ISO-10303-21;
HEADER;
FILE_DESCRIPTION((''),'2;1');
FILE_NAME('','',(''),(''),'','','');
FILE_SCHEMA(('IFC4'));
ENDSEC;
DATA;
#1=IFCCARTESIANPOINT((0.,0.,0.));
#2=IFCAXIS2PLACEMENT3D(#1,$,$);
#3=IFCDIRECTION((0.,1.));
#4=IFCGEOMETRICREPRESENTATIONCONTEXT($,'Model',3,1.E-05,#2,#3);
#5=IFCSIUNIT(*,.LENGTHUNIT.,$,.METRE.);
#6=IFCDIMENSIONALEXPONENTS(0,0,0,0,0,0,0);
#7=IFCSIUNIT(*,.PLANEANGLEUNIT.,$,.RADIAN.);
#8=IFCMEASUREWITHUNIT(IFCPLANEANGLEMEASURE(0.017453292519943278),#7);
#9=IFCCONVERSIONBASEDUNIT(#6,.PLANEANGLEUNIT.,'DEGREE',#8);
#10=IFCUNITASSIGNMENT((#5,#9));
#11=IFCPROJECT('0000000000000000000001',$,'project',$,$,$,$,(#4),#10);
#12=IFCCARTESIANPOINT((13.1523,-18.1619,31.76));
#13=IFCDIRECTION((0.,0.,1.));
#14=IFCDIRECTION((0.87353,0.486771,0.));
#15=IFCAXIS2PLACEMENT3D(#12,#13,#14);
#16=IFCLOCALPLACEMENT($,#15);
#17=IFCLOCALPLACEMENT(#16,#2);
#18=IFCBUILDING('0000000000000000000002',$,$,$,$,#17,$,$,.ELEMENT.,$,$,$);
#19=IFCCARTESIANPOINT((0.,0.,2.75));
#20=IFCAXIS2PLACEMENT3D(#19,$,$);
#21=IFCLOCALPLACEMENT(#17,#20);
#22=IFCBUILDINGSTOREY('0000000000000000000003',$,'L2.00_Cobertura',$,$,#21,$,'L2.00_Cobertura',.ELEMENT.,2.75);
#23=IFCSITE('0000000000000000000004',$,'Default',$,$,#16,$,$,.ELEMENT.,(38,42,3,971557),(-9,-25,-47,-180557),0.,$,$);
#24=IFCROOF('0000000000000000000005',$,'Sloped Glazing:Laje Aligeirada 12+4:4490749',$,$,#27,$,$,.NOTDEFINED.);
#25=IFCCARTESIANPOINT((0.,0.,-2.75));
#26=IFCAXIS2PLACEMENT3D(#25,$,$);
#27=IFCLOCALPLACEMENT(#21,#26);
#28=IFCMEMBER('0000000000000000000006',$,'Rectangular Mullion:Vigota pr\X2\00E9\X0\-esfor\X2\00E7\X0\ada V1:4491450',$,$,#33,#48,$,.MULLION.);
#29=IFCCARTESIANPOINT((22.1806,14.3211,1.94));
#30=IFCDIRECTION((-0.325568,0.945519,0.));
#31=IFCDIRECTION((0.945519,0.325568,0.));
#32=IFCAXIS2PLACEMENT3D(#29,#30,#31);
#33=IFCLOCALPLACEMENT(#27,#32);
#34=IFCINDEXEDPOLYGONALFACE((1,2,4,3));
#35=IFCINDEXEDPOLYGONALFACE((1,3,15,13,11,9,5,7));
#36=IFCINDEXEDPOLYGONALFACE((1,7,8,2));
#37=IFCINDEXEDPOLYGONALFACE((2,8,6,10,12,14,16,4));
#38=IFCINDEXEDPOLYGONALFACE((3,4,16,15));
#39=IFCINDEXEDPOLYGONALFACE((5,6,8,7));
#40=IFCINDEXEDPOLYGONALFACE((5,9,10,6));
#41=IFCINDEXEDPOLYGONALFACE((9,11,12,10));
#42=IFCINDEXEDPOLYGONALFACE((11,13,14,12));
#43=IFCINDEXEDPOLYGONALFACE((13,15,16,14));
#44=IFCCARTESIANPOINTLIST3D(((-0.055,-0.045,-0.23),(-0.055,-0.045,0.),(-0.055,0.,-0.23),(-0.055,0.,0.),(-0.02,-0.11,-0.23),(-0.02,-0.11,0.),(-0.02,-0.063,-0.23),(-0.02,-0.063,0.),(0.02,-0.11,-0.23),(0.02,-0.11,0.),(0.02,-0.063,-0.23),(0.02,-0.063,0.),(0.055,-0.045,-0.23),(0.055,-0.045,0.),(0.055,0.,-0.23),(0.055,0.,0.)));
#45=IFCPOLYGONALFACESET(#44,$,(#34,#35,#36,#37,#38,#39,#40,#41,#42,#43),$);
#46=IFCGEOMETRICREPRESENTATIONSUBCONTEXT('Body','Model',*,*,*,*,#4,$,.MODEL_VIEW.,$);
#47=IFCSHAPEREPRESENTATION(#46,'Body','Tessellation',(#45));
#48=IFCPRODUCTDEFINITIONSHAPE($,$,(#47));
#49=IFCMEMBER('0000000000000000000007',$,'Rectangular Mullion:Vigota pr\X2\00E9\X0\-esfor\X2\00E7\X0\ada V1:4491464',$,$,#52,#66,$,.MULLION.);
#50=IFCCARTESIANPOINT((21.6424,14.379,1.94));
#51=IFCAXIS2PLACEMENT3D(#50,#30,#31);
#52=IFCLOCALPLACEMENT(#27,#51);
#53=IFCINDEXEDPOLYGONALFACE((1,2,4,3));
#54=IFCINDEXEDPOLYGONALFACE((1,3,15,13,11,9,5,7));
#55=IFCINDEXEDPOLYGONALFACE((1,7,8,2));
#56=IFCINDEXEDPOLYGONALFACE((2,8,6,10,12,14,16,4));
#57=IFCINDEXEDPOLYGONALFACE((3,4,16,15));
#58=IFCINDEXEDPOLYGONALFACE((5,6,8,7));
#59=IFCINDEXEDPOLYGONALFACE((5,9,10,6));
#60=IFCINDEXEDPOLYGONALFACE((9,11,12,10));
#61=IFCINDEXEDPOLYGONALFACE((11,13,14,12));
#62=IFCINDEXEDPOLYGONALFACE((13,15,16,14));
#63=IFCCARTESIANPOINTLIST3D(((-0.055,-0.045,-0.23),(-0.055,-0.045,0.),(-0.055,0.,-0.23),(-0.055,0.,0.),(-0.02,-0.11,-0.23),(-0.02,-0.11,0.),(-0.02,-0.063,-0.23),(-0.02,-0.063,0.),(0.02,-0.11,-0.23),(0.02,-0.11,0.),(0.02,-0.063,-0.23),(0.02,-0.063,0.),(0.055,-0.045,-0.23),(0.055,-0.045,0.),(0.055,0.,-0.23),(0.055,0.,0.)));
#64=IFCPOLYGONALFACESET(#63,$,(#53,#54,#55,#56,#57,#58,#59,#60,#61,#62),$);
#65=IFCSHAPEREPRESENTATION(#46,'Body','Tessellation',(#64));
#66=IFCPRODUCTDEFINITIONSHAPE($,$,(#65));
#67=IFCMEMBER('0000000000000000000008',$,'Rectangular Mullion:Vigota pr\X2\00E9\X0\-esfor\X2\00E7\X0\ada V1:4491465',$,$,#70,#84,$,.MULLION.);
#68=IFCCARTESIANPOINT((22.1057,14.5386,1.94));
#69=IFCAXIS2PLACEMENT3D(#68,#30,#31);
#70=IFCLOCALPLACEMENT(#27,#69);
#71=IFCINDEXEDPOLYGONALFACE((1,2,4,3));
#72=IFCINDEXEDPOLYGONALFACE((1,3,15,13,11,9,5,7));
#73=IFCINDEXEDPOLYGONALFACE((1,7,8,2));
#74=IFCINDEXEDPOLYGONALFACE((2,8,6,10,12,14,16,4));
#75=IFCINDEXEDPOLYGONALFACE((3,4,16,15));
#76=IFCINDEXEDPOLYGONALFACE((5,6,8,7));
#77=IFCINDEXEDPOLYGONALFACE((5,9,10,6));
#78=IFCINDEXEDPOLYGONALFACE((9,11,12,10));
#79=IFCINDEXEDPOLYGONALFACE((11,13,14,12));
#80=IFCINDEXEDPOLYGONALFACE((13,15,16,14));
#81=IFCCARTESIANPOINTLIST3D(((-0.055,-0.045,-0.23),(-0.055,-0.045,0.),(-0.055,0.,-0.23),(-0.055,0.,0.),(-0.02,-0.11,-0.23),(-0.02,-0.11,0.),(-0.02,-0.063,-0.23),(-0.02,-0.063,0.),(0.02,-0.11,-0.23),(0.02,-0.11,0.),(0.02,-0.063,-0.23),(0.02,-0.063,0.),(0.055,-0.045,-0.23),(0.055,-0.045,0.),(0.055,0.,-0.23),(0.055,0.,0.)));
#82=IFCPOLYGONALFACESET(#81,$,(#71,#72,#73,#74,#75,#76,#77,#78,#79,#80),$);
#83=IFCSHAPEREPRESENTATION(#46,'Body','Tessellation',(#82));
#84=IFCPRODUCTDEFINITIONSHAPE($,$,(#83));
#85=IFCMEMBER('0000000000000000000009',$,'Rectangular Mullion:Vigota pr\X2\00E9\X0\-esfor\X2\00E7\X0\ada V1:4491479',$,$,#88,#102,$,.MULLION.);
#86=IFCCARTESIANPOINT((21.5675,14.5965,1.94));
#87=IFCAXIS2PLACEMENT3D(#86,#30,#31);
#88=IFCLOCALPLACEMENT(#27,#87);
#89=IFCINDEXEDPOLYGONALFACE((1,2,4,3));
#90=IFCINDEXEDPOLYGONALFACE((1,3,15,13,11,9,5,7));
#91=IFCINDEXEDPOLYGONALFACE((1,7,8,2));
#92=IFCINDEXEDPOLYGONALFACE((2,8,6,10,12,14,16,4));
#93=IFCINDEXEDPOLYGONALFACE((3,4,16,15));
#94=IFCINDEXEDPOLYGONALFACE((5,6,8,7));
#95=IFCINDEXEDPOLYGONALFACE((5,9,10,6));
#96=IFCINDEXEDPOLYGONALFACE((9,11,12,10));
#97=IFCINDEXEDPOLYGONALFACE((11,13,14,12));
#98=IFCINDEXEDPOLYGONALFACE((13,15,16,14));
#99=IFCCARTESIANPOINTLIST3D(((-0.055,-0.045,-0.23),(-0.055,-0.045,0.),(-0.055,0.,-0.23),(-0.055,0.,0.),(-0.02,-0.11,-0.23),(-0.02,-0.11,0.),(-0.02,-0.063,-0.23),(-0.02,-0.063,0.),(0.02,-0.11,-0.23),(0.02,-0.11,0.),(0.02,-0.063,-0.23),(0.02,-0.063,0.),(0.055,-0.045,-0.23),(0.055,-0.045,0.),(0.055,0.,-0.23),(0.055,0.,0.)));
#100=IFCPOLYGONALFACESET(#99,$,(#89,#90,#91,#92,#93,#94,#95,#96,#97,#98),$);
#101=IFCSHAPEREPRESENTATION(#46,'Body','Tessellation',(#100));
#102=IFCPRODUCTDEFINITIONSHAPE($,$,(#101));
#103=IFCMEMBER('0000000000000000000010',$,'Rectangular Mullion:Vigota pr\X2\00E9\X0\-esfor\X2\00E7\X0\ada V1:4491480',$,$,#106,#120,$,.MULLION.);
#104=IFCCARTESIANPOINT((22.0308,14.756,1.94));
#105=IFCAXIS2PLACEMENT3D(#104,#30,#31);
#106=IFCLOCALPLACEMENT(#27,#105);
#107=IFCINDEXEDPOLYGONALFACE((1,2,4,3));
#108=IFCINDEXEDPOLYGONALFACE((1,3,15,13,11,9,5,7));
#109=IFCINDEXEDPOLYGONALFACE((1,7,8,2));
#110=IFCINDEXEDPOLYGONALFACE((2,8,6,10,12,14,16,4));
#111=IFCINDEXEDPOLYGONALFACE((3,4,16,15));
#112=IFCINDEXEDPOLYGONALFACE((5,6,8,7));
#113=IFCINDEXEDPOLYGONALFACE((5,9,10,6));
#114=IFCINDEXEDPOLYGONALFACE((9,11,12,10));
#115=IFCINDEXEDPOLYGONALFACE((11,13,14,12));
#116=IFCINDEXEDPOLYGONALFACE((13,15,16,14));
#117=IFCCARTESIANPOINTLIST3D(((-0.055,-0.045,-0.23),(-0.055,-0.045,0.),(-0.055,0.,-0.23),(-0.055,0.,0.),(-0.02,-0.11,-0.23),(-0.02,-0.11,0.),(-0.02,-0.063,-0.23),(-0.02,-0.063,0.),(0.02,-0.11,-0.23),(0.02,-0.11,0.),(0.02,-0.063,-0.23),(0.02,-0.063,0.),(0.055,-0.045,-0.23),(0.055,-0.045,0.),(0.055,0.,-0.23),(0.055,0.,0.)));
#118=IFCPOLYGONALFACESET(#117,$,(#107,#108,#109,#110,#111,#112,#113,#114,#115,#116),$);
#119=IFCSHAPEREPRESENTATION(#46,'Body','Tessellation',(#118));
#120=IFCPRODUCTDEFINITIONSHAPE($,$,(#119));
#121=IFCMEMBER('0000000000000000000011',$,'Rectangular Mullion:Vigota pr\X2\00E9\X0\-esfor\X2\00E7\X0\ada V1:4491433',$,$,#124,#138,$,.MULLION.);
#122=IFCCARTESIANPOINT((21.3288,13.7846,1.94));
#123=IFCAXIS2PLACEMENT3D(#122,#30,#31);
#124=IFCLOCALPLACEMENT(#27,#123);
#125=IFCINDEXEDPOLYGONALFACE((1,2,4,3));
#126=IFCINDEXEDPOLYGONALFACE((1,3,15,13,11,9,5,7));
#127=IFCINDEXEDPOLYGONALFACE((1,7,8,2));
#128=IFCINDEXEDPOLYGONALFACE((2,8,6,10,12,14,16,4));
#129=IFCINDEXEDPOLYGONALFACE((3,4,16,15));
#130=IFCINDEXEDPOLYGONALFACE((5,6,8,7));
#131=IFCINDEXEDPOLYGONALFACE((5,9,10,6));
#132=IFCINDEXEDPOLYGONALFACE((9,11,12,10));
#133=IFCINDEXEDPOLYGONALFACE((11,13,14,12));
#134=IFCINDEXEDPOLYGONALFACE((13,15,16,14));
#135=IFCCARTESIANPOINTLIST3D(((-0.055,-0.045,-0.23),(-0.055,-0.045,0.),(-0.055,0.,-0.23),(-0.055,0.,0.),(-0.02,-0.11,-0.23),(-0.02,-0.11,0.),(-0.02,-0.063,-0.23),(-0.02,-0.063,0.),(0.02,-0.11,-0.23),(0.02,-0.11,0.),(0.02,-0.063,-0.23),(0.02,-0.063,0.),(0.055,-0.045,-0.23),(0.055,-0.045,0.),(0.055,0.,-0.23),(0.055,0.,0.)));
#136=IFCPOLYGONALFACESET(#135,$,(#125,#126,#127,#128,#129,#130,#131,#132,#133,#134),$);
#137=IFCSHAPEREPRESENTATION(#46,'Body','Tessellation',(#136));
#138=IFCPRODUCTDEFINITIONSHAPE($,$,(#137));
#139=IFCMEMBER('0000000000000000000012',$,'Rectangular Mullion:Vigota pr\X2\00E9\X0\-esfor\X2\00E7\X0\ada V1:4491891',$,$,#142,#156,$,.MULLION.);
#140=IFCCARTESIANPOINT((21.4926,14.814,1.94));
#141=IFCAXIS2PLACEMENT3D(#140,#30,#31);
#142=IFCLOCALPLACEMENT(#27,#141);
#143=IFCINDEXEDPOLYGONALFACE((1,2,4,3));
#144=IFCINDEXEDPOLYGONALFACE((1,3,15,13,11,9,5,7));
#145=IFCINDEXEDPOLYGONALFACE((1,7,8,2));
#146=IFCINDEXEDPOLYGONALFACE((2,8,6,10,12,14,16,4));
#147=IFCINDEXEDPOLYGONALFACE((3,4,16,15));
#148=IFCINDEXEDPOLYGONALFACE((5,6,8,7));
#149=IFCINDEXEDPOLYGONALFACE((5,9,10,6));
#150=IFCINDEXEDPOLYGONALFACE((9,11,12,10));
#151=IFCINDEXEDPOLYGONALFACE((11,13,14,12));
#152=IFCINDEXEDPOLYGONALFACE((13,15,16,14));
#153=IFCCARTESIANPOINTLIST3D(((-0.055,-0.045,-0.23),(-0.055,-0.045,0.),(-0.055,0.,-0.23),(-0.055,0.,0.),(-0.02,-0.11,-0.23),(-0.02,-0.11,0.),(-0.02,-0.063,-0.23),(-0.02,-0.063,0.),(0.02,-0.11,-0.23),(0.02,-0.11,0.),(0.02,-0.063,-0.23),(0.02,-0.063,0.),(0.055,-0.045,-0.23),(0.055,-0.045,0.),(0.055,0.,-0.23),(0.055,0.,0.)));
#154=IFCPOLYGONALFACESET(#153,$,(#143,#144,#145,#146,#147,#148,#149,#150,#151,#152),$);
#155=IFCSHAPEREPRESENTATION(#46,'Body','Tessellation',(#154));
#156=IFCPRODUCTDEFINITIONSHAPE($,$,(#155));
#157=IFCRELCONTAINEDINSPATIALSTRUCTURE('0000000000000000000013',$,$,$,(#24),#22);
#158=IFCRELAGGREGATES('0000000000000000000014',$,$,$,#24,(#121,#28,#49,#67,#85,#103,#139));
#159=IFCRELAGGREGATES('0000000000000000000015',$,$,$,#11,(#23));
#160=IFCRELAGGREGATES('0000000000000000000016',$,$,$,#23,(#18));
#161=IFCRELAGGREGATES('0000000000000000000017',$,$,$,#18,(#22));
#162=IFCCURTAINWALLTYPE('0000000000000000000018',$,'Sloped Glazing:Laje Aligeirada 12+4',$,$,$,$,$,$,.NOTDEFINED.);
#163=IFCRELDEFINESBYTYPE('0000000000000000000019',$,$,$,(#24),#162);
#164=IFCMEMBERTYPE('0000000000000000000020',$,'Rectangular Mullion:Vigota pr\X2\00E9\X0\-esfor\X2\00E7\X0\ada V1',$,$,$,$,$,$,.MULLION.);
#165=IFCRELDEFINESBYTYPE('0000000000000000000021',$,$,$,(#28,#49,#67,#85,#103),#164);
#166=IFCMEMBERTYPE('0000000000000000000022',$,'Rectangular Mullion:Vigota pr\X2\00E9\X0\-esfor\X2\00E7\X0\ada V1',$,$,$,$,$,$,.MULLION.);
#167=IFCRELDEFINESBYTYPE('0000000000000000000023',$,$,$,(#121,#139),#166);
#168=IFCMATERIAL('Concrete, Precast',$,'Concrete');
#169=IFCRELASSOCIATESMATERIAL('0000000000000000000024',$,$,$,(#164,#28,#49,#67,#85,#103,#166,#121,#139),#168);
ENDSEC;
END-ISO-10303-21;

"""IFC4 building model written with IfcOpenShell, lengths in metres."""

from ifc_helpers import new_model, entity, si_unit, converted_unit, direction, frame, origin, place, context, subcontext, project, spatial, indexed_curve, outline, extrude, source, transform, mapped, material, type_object, type_shapes, element, aggregate, save


model = new_model("IFC4")

# Units and contexts
model_context = context("Model", 3, precision=1e-05, world=origin(), true_north=direction((0.0, 1.0)))
body_context = subcontext(model_context, "Body", "Model", "MODEL_VIEW")
ifc_project = project(units=[si_unit("LENGTHUNIT", "METRE"), converted_unit("PLANEANGLEUNIT", "DEGREE", entity("IfcPlaneAngleMeasure", 0.017453292519943278), si_unit("PLANEANGLEUNIT", "RADIAN"), dimensions=[0, 0, 0, 0, 0, 0, 0])], contexts=[model_context])

# Site, building, storey
site_placement = place(None, frame((13.1523, -18.1619, 31.76), z_axis=(0.0, 0.0, 1.0), x_axis=(0.87353, 0.486771, 0.0)))
site = spatial("IfcSite", under=ifc_project, at=site_placement, Name="Default", CompositionType="ELEMENT", RefLatitude=(38, 42, 3, 971557), RefLongitude=(-9, -25, -47, -180557), RefElevation=0.0)
building_placement = place(site_placement, origin())
building = spatial("IfcBuilding", under=site, at=building_placement, CompositionType="ELEMENT")
storey_placement = place(building_placement, frame((0.0, 0.0, 2.75)))
storey = spatial("IfcBuildingStorey", under=building, at=storey_placement, Name="L2.00_Cobertura", LongName="L2.00_Cobertura", CompositionType="ELEMENT", Elevation=2.75)

# Roof, members
curtain_wall_type = type_object("IfcCurtainWallType", Name="Sloped Glazing:Laje Aligeirada 12+4", PredefinedType="NOTDEFINED")
roof_placement = place(storey_placement, frame((0.0, 0.0, -2.75)))
roof = element("IfcRoof", 1, at=roof_placement, inside=storey, type_object=curtain_wall_type, Name="Sloped Glazing:Laje Aligeirada 12+4:4490749", PredefinedType="NOTDEFINED")
ifc_material_1 = material(Name="Concrete, Precast", Category="Concrete")
member_type_1 = type_object("IfcMemberType", Name="Rectangular Mullion:Vigota pré-esforçada V1", PredefinedType="MULLION", material=ifc_material_1)
shared_shape_1 = source(origin(), body_context, "Body", "SweptSolid", [
    extrude(outline(indexed_curve([(-0.055, -0.0545), (0.055, -0.0545), (0.055, -0.0095), (0.02, 0.0085), (0.02, 0.0555), (-0.02, 0.0555), (-0.02, 0.0085), (-0.055, -0.0095), (-0.055, -0.0545)], self_intersect=False)), frame((0.0, -0.0545, -0.23), z_axis=(0.0, 0.0, 1.0), x_axis=(-1.0, 0.0, 0.0)), (0.0, 0.0, 1.0), 0.23),
])
type_shapes(member_type_1, [shared_shape_1])
member_1_placement = place(roof_placement, frame((22.1806, 14.3211, 1.94), z_axis=(-0.325568, 0.945519, 0.0), x_axis=(0.945519, 0.325568, 0.0)))
member_1 = element("IfcMember", 2, at=member_1_placement, type_object=member_type_1, material=ifc_material_1, Name="Rectangular Mullion:Vigota pré-esforçada V1:4491450", PredefinedType="MULLION", context=body_context, shape_type="MappedRepresentation", body=[
    mapped(shared_shape_1, transform((0.0, 0.0, 0.0), scale=1.0)),
])
member_2_placement = place(roof_placement, frame((21.6424, 14.379, 1.94), z_axis=(-0.325568, 0.945519, 0.0), x_axis=(0.945519, 0.325568, 0.0)))
member_2 = element("IfcMember", 3, at=member_2_placement, type_object=member_type_1, material=ifc_material_1, Name="Rectangular Mullion:Vigota pré-esforçada V1:4491464", PredefinedType="MULLION", context=body_context, shape_type="MappedRepresentation", body=[
    mapped(shared_shape_1, transform((0.0, 0.0, 0.0), scale=1.0)),
])
member_3_placement = place(roof_placement, frame((22.1057, 14.5386, 1.94), z_axis=(-0.325568, 0.945519, 0.0), x_axis=(0.945519, 0.325568, 0.0)))
member_3 = element("IfcMember", 4, at=member_3_placement, type_object=member_type_1, material=ifc_material_1, Name="Rectangular Mullion:Vigota pré-esforçada V1:4491465", PredefinedType="MULLION", context=body_context, shape_type="MappedRepresentation", body=[
    mapped(shared_shape_1, transform((0.0, 0.0, 0.0), scale=1.0)),
])
member_4_placement = place(roof_placement, frame((21.5675, 14.5965, 1.94), z_axis=(-0.325568, 0.945519, 0.0), x_axis=(0.945519, 0.325568, 0.0)))
member_4 = element("IfcMember", 5, at=member_4_placement, type_object=member_type_1, material=ifc_material_1, Name="Rectangular Mullion:Vigota pré-esforçada V1:4491479", PredefinedType="MULLION", context=body_context, shape_type="MappedRepresentation", body=[
    mapped(shared_shape_1, transform((0.0, 0.0, 0.0), scale=1.0)),
])
member_5_placement = place(roof_placement, frame((22.0308, 14.756, 1.94), z_axis=(-0.325568, 0.945519, 0.0), x_axis=(0.945519, 0.325568, 0.0)))
member_5 = element("IfcMember", 6, at=member_5_placement, type_object=member_type_1, material=ifc_material_1, Name="Rectangular Mullion:Vigota pré-esforçada V1:4491480", PredefinedType="MULLION", context=body_context, shape_type="MappedRepresentation", body=[
    mapped(shared_shape_1, transform((0.0, 0.0, 0.0), scale=1.0)),
])
member_type_2 = type_object("IfcMemberType", Name="Rectangular Mullion:Vigota pré-esforçada V1", PredefinedType="MULLION", material=ifc_material_1)
shared_shape_2 = source(origin(), body_context, "Body", "SweptSolid", [
    extrude(outline(indexed_curve([(-0.055, -0.0545), (0.055, -0.0545), (0.055, -0.0095), (0.02, 0.0085), (0.02, 0.0555), (-0.02, 0.0555), (-0.02, 0.0085), (-0.055, -0.0095), (-0.055, -0.0545)], self_intersect=False)), frame((0.0, -0.0545, -0.23), z_axis=(0.0, 0.0, 1.0), x_axis=(-1.0, 0.0, 0.0)), (0.0, 0.0, 1.0), 0.23),
])
type_shapes(member_type_2, [shared_shape_2])
member_6_placement = place(roof_placement, frame((21.3288, 13.7846, 1.94), z_axis=(-0.325568, 0.945519, 0.0), x_axis=(0.945519, 0.325568, 0.0)))
member_6 = element("IfcMember", 7, at=member_6_placement, type_object=member_type_2, material=ifc_material_1, Name="Rectangular Mullion:Vigota pré-esforçada V1:4491433", PredefinedType="MULLION", context=body_context, shape_type="MappedRepresentation", body=[
    mapped(shared_shape_2, transform((0.0, 0.0, 0.0), scale=1.0)),
])
member_7_placement = place(roof_placement, frame((21.4926, 14.814, 1.94), z_axis=(-0.325568, 0.945519, 0.0), x_axis=(0.945519, 0.325568, 0.0)))
member_7 = element("IfcMember", 8, at=member_7_placement, type_object=member_type_2, material=ifc_material_1, Name="Rectangular Mullion:Vigota pré-esforçada V1:4491891", PredefinedType="MULLION", context=body_context, shape_type="MappedRepresentation", body=[
    mapped(shared_shape_2, transform((0.0, 0.0, 0.0), scale=1.0)),
])
aggregate(roof, [member_6, member_1, member_2, member_3, member_4, member_5, member_7])

save(model, "model.ifc")
